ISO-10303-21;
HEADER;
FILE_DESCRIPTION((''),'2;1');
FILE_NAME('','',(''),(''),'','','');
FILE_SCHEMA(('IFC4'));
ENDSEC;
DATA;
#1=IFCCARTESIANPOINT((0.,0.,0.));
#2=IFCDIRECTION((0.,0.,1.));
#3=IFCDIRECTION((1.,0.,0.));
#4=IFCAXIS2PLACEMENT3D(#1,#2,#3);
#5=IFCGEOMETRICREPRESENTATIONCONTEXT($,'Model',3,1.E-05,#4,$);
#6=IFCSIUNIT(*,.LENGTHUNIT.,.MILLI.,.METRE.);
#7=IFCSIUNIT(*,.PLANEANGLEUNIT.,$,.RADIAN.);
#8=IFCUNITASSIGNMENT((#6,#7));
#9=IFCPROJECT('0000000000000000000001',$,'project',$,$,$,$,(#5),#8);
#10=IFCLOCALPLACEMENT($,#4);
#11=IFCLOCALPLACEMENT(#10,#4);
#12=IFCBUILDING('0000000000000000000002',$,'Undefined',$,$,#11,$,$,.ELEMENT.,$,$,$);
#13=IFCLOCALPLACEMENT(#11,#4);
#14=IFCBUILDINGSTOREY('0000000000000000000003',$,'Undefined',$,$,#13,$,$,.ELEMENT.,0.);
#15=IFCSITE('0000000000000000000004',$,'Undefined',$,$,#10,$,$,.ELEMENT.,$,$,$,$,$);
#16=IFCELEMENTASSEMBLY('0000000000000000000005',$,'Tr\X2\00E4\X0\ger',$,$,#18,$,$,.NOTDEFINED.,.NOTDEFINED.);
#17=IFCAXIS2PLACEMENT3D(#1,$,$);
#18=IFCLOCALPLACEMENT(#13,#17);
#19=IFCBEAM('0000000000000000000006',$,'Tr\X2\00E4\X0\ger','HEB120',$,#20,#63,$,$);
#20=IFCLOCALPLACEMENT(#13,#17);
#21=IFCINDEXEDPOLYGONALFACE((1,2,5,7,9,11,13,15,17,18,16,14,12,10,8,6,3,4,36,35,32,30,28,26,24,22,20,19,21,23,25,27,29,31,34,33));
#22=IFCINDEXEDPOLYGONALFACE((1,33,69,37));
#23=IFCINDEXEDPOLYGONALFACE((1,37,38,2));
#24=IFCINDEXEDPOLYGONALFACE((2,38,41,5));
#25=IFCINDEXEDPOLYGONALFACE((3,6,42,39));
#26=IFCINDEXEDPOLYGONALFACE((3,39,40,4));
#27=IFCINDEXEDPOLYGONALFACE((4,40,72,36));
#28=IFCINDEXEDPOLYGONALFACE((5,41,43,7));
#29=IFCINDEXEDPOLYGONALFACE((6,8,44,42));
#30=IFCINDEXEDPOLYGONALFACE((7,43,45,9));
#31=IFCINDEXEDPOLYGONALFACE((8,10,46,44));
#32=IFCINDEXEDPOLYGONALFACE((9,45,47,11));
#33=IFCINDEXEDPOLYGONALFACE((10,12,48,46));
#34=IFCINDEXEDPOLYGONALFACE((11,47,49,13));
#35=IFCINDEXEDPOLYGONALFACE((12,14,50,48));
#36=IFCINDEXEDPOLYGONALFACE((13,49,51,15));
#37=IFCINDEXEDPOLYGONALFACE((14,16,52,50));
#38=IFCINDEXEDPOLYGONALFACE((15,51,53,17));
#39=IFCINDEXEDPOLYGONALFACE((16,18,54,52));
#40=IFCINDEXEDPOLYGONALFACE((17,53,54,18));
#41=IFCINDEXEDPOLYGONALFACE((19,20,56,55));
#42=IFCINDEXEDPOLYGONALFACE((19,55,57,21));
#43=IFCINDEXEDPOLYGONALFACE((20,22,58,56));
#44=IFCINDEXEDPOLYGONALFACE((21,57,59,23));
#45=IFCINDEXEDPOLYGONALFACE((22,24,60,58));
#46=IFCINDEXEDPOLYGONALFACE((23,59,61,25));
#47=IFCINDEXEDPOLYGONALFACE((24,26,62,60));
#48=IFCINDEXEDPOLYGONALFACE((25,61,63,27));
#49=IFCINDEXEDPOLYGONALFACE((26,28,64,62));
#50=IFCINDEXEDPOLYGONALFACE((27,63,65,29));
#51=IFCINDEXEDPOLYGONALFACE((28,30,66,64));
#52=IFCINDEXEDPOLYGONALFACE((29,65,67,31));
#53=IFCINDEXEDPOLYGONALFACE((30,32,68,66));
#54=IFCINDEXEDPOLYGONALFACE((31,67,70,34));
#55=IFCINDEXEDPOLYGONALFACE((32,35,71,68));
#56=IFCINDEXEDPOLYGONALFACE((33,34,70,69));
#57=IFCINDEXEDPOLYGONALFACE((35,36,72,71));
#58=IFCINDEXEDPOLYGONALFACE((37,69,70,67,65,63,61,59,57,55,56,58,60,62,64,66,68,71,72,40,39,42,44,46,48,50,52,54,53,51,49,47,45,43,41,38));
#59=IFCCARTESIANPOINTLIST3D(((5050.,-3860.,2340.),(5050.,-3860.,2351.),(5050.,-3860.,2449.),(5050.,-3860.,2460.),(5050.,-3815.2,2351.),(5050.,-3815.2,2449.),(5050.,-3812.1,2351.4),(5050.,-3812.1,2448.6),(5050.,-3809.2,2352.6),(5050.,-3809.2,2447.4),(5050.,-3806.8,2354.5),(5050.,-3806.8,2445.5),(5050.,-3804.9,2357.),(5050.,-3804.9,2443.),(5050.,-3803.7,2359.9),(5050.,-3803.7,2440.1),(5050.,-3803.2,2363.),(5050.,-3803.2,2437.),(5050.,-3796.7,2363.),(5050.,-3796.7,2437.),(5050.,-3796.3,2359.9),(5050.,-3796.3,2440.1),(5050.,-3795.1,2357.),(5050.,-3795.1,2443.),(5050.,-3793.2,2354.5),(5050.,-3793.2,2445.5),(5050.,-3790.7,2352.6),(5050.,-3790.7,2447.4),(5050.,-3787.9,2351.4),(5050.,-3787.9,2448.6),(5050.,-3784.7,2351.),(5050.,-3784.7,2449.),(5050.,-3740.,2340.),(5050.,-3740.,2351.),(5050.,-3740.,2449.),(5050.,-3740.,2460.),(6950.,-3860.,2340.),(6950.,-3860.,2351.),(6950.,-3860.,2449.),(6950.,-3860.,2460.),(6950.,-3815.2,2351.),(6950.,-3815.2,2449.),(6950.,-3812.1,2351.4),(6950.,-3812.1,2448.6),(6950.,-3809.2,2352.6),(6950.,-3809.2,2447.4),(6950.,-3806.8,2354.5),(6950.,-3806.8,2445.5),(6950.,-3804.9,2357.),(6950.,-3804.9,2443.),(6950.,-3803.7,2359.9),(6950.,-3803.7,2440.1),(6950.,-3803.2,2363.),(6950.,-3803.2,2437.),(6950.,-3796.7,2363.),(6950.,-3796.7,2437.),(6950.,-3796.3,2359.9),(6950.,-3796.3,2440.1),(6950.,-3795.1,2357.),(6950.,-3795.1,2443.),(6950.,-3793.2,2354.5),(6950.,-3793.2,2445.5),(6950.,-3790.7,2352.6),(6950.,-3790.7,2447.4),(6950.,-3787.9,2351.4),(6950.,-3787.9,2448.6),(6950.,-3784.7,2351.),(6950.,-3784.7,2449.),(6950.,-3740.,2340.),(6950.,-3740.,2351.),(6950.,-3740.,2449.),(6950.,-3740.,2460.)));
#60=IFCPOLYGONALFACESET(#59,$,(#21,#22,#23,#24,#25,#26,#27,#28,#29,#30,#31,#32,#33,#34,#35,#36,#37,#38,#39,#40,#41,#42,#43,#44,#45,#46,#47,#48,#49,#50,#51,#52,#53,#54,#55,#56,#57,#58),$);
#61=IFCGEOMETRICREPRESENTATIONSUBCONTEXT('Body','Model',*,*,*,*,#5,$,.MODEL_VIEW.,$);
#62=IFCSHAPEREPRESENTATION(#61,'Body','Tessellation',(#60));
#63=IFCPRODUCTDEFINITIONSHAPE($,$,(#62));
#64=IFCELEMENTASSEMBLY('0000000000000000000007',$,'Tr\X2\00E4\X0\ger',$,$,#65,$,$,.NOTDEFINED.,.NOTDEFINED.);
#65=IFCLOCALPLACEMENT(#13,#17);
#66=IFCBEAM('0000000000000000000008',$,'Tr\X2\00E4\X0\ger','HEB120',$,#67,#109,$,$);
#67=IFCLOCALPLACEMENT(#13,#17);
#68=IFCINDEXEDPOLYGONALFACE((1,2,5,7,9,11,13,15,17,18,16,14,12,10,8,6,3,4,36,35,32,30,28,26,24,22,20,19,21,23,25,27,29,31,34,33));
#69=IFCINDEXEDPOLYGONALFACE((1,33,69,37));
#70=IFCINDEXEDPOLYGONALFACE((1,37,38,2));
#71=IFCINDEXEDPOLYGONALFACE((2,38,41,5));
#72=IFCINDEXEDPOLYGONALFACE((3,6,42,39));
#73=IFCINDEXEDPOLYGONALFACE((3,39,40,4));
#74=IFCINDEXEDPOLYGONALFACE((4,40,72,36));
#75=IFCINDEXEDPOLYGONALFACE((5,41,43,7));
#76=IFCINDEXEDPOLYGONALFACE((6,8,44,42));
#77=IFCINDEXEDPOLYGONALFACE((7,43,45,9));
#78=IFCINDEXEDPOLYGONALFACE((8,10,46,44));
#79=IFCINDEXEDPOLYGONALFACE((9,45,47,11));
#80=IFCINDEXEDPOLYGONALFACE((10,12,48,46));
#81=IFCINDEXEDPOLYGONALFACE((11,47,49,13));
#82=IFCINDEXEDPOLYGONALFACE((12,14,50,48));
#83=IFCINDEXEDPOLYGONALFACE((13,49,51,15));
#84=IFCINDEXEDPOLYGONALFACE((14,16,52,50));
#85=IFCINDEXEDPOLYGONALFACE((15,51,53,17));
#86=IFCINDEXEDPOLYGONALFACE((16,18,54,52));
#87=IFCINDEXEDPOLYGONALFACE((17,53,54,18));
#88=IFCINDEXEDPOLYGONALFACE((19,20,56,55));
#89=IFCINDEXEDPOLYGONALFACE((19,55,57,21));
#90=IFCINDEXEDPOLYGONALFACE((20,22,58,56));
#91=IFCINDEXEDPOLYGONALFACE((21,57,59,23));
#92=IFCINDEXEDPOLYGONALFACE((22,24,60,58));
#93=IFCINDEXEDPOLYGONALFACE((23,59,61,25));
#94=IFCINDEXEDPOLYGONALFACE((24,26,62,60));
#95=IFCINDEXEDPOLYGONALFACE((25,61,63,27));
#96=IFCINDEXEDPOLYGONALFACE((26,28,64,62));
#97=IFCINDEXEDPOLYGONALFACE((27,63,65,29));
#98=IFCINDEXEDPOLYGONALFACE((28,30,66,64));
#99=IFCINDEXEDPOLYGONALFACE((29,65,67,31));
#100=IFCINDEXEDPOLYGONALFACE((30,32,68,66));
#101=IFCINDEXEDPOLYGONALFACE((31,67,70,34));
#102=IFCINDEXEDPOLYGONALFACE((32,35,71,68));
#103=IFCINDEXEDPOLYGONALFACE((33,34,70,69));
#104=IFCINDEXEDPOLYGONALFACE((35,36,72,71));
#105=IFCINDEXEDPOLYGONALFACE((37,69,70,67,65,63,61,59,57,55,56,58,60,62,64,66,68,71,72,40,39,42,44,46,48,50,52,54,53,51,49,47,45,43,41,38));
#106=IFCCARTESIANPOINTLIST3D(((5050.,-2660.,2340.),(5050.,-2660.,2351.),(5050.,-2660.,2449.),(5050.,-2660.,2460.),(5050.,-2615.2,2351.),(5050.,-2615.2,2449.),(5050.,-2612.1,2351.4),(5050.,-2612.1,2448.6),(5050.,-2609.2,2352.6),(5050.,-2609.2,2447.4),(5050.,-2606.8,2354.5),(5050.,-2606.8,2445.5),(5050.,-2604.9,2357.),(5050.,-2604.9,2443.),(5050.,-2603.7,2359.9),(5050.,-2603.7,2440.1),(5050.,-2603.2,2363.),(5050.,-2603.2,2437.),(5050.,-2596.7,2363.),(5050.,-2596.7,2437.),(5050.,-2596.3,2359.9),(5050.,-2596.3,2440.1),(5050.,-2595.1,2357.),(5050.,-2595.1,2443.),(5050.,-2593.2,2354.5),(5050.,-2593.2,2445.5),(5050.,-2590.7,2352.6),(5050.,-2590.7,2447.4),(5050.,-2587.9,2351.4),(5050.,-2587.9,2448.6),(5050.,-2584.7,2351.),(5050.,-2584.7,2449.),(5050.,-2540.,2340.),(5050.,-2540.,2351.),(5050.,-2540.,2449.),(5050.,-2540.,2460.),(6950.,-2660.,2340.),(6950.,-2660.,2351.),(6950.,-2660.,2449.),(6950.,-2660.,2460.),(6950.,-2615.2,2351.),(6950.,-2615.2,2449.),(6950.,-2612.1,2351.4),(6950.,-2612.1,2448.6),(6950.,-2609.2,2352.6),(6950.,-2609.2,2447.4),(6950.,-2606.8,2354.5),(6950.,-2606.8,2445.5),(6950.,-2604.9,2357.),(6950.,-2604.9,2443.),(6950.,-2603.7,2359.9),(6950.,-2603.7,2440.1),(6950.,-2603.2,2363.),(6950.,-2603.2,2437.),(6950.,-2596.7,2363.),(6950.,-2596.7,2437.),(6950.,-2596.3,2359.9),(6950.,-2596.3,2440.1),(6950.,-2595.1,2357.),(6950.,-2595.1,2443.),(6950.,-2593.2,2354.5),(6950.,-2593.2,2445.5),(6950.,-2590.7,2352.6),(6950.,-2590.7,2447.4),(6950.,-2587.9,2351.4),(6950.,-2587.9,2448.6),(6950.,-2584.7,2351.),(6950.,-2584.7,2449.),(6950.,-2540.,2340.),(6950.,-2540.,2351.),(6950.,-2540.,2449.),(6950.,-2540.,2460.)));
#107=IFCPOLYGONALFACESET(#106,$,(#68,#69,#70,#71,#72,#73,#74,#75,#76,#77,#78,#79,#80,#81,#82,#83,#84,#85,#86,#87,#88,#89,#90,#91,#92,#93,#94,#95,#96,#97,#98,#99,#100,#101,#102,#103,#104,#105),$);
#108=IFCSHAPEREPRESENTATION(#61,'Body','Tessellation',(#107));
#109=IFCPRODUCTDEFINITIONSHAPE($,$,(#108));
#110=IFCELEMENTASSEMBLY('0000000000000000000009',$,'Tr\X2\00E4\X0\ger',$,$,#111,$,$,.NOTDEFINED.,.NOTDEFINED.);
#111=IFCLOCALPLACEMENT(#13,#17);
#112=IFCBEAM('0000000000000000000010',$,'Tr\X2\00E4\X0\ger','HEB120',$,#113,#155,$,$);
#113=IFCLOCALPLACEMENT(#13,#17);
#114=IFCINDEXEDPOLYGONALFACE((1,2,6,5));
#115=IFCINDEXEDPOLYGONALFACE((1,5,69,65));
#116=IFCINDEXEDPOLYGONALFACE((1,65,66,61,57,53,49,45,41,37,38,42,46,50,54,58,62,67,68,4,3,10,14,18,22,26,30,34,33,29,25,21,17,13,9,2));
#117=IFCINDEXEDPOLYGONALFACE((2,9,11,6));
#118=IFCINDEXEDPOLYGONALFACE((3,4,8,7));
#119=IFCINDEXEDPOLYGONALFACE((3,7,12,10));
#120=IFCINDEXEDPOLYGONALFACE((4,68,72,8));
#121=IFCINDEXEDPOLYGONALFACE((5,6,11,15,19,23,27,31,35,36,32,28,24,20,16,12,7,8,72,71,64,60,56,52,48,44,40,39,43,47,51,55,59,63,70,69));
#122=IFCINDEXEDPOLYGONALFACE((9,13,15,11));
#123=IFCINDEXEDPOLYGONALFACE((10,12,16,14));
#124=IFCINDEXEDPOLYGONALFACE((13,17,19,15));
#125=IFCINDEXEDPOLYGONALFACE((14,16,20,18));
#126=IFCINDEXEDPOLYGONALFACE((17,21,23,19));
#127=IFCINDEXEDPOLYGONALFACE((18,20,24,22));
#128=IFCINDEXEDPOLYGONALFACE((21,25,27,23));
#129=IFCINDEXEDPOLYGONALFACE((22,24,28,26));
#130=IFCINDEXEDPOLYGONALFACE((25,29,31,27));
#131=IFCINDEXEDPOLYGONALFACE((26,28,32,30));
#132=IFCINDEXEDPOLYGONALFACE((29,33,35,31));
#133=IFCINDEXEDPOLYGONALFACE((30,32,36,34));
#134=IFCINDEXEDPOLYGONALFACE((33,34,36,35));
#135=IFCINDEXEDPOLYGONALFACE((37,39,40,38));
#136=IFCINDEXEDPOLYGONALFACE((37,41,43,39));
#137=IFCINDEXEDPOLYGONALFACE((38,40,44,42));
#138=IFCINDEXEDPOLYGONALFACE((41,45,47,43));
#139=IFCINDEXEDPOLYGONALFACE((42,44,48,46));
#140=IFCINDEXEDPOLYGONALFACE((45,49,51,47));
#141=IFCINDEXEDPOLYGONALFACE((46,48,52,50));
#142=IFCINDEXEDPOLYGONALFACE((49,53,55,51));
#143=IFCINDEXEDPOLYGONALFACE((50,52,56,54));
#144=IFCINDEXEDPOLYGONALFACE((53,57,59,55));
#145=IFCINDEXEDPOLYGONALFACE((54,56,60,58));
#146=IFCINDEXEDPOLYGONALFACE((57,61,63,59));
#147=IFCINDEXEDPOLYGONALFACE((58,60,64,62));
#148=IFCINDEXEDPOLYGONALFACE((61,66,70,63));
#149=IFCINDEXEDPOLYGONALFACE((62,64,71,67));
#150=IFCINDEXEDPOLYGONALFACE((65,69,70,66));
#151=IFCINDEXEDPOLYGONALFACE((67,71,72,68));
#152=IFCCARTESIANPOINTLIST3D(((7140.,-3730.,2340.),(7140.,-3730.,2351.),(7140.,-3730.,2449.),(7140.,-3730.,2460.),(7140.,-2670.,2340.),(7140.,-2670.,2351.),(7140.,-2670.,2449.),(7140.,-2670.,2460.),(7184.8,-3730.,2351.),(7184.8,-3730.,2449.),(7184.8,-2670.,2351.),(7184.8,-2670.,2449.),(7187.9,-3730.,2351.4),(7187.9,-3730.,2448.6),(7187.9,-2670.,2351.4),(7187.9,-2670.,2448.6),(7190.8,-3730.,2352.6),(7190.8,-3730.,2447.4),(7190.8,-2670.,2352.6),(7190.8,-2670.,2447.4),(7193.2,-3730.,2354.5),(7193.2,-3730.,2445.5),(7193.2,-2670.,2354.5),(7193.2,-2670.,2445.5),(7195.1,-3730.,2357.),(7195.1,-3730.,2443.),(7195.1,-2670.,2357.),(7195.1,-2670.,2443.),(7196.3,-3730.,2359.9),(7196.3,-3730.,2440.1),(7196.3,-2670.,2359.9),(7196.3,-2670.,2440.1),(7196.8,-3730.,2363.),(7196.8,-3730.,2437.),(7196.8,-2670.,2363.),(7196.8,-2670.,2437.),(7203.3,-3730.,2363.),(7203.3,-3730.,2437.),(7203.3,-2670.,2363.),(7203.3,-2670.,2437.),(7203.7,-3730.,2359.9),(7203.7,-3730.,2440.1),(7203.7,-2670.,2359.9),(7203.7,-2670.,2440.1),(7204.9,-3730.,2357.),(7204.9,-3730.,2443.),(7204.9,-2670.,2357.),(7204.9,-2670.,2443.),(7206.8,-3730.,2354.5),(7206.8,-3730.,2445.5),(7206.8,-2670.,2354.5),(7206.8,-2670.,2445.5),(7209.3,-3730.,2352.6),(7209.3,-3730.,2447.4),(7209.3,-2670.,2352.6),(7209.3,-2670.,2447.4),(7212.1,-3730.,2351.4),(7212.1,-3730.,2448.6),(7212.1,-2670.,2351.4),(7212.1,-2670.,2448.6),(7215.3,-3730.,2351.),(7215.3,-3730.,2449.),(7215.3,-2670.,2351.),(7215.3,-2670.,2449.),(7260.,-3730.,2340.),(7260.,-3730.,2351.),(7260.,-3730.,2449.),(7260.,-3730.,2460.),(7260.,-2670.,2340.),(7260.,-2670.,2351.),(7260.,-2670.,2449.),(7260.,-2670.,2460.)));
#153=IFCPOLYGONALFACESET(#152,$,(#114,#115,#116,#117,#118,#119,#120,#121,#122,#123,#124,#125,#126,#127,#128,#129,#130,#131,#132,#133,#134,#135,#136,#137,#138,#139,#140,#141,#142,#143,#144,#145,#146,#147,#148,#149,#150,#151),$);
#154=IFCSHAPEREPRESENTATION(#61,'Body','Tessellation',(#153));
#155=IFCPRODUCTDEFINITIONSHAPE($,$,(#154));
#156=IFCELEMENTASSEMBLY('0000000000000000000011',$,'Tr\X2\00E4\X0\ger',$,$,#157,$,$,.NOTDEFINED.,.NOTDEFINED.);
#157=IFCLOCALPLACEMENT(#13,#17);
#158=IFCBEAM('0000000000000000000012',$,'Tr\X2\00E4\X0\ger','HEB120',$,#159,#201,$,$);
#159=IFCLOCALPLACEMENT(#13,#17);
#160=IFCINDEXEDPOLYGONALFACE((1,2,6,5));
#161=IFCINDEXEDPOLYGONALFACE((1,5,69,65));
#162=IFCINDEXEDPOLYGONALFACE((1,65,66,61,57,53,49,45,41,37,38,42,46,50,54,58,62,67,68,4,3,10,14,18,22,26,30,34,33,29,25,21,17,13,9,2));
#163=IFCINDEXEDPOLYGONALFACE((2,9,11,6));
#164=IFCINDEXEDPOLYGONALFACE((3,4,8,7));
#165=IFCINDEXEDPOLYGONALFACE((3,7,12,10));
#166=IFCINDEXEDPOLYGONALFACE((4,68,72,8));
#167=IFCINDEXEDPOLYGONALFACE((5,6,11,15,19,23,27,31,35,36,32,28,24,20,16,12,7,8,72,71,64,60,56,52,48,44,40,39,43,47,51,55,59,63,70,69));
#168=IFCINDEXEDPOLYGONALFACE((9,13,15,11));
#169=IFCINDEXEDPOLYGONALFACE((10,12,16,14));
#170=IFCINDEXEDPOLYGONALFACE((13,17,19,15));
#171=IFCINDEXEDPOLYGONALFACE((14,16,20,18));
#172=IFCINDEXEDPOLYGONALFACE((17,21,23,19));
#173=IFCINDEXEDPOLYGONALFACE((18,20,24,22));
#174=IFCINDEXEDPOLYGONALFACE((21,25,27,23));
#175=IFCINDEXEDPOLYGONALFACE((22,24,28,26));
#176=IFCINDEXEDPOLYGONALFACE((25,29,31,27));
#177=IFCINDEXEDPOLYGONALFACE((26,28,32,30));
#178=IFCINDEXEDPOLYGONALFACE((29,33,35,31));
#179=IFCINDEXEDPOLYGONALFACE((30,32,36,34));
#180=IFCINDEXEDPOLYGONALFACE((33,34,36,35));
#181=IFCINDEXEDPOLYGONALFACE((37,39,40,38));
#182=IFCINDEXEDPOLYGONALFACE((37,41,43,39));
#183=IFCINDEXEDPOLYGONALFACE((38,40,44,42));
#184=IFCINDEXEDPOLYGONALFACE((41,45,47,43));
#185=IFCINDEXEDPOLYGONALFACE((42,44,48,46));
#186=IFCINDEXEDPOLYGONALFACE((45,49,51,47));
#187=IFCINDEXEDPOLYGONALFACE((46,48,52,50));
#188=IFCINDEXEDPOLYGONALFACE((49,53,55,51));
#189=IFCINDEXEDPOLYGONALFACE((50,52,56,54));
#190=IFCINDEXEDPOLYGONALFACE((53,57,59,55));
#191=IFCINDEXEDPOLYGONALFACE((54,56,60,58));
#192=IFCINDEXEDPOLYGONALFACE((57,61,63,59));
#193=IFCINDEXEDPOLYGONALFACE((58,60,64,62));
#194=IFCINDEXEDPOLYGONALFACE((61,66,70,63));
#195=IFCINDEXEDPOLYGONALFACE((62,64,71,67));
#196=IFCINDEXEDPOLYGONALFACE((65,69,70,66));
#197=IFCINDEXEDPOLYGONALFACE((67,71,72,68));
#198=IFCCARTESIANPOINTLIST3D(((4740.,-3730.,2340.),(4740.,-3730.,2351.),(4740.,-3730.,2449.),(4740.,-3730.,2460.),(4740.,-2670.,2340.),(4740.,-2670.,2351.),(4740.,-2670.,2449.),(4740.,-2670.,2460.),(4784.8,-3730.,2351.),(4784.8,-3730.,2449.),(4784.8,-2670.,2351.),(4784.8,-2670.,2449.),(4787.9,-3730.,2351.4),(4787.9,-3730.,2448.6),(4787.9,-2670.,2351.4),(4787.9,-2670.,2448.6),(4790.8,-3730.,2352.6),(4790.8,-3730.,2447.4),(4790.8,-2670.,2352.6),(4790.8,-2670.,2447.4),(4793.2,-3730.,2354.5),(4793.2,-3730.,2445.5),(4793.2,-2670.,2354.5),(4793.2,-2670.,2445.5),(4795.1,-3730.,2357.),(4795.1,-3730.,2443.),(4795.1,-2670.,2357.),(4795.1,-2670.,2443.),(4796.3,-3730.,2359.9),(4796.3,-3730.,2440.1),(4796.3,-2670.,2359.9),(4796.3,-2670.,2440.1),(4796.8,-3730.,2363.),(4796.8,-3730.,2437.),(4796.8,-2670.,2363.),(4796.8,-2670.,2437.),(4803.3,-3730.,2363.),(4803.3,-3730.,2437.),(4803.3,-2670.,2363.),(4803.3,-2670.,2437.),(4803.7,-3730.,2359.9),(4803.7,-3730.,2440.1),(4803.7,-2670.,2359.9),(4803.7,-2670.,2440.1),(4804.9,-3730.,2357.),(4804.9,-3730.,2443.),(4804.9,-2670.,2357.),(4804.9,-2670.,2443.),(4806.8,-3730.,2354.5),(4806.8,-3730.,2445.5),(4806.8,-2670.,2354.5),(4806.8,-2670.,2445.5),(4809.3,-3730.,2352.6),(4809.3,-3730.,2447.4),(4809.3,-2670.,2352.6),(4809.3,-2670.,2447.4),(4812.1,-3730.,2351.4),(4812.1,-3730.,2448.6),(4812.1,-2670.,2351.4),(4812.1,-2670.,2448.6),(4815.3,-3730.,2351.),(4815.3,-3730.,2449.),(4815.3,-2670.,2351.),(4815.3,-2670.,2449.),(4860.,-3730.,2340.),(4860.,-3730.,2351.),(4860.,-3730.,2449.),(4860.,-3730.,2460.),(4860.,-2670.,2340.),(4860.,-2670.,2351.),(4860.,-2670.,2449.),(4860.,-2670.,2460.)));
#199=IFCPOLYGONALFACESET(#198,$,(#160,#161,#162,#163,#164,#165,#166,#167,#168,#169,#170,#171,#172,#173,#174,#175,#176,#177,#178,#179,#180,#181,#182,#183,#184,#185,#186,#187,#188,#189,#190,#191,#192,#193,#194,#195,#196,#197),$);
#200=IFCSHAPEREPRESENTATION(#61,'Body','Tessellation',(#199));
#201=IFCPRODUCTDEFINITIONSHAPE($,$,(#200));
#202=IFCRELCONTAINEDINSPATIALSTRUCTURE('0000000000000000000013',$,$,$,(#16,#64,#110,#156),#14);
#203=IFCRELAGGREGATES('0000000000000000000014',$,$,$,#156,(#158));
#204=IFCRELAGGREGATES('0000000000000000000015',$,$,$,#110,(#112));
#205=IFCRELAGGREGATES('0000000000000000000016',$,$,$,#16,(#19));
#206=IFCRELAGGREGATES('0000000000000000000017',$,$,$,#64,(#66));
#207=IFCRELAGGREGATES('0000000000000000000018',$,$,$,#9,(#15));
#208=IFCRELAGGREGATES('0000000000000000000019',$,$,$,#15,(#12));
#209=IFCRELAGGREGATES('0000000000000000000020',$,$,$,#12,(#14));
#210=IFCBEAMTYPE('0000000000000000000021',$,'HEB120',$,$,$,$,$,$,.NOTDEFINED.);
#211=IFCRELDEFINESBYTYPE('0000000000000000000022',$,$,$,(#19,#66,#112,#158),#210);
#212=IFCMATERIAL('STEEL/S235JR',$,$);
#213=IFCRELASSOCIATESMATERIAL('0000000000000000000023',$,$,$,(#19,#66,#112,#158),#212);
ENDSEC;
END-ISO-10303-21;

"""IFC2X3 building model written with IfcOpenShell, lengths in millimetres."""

from ifc_helpers import new_model, si_unit, frame, origin_with_axes, origin_2d_with_axis, place, context, subcontext, project, spatial, i_section, extrude, clip, halfspace, material, type_object, element, aggregate, save


model = new_model("IFC2X3")

# Units and contexts
model_context = context("Model", 3, precision=1e-05, world=origin_with_axes())
body_context = subcontext(model_context, "Body", "Model", "MODEL_VIEW")
ifc_project = project(units=[si_unit("LENGTHUNIT", "METRE", prefix="MILLI"), si_unit("PLANEANGLEUNIT", "RADIAN")], contexts=[model_context])

# Site, building, storey
site_placement = place(None, origin_with_axes())
site = spatial("IfcSite", under=ifc_project, at=site_placement, Name="Undefined", CompositionType="ELEMENT")
building_placement = place(site_placement, origin_with_axes())
building = spatial("IfcBuilding", under=site, at=building_placement, Name="Undefined", CompositionType="ELEMENT")
storey_placement = place(building_placement, origin_with_axes())
storey = spatial("IfcBuildingStorey", under=building, at=storey_placement, Name="Undefined", CompositionType="ELEMENT", Elevation=0.0)

# Element assemblies, beams
ifc_material_1 = material(Name="STEEL/S235JR")
beam_type = type_object("IfcBeamType", Name="HEB120", PredefinedType="NOTDEFINED")
assembly_1_placement = place(storey_placement, origin_with_axes())
assembly_1 = element("IfcElementAssembly", 1, at=assembly_1_placement, inside=storey, Name="Träger", AssemblyPlace="NOTDEFINED", PredefinedType="NOTDEFINED")
beam_1_placement = place(assembly_1_placement, frame((6950.0, -3800.0, 2400.0), z_axis=(0.0, 0.0, 1.0), x_axis=(-1.0, 0.0, 0.0)))
beam_1 = element("IfcBeam", 2, at=beam_1_placement, type_object=beam_type, material=ifc_material_1, Name="Träger", Description="HEB120", context=body_context, shape_type="Clipping", body=[
    clip(clip(extrude(i_section(OverallWidth=120.0, OverallDepth=120.0, WebThickness=6.5, FlangeThickness=11.0, FilletRadius=12.0, at=origin_2d_with_axis()), frame((1910.0, 0.0, 0.0), z_axis=(-1.0, 0.0, 0.0), x_axis=(0.0, -1.0, 0.0)), (0.0, 0.0, 1.0), 1910.0), halfspace(frame((1900.0, 0.0, -60.0), z_axis=(-1.0, 0.0, 0.0), x_axis=(0.0, 1.0, 0.0)), True)), halfspace(frame((0.0, 0.0, -60.0), z_axis=(1.0, 0.0, 0.0), x_axis=(0.0, -1.0, 0.0)), True)),
])
assembly_2_placement = place(storey_placement, origin_with_axes())
assembly_2 = element("IfcElementAssembly", 3, at=assembly_2_placement, inside=storey, Name="Träger", AssemblyPlace="NOTDEFINED", PredefinedType="NOTDEFINED")
beam_2_placement = place(assembly_2_placement, frame((6950.0, -2600.0, 2400.0), z_axis=(0.0, 0.0, 1.0), x_axis=(-1.0, 0.0, 0.0)))
beam_2 = element("IfcBeam", 4, at=beam_2_placement, type_object=beam_type, material=ifc_material_1, Name="Träger", Description="HEB120", context=body_context, shape_type="Clipping", body=[
    clip(clip(extrude(i_section(OverallWidth=120.0, OverallDepth=120.0, WebThickness=6.5, FlangeThickness=11.0, FilletRadius=12.0, at=origin_2d_with_axis()), frame((1910.0, 0.0, 0.0), z_axis=(-1.0, 0.0, 0.0), x_axis=(0.0, -1.0, 0.0)), (0.0, 0.0, 1.0), 1910.0), halfspace(frame((1900.0, 0.0, -60.0), z_axis=(-1.0, 0.0, 0.0), x_axis=(0.0, 1.0, 0.0)), True)), halfspace(frame((0.0, 0.0, -60.0), z_axis=(1.0, 0.0, 0.0), x_axis=(0.0, -1.0, 0.0)), True)),
])
assembly_3_placement = place(storey_placement, origin_with_axes())
assembly_3 = element("IfcElementAssembly", 5, at=assembly_3_placement, inside=storey, Name="Träger", AssemblyPlace="NOTDEFINED", PredefinedType="NOTDEFINED")
beam_3_placement = place(assembly_3_placement, frame((7200.0, -2670.0, 2400.0), z_axis=(0.0, 0.0, 1.0), x_axis=(0.0, -1.0, 0.0)))
beam_3 = element("IfcBeam", 6, at=beam_3_placement, type_object=beam_type, material=ifc_material_1, Name="Träger", Description="HEB120", context=body_context, shape_type="Clipping", body=[
    clip(clip(extrude(i_section(OverallWidth=120.0, OverallDepth=120.0, WebThickness=6.5, FlangeThickness=11.0, FilletRadius=12.0, at=origin_2d_with_axis()), frame((1060.0, 0.0, 0.0), z_axis=(-1.0, 0.0, 0.0), x_axis=(0.0, -1.0, 0.0)), (0.0, 0.0, 1.0), 1060.0), halfspace(frame((1060.0, 0.0, -60.0), z_axis=(-1.0, 0.0, 0.0), x_axis=(0.0, 1.0, 0.0)), True)), halfspace(frame((0.0, 0.0, -60.0), z_axis=(1.0, 0.0, 0.0), x_axis=(0.0, -1.0, 0.0)), True)),
])
assembly_4_placement = place(storey_placement, origin_with_axes())
assembly_4 = element("IfcElementAssembly", 7, at=assembly_4_placement, inside=storey, Name="Träger", AssemblyPlace="NOTDEFINED", PredefinedType="NOTDEFINED")
beam_4_placement = place(assembly_4_placement, frame((4800.0, -2670.0, 2400.0), z_axis=(0.0, 0.0, 1.0), x_axis=(0.0, -1.0, 0.0)))
beam_4 = element("IfcBeam", 8, at=beam_4_placement, type_object=beam_type, material=ifc_material_1, Name="Träger", Description="HEB120", context=body_context, shape_type="Clipping", body=[
    clip(clip(extrude(i_section(OverallWidth=120.0, OverallDepth=120.0, WebThickness=6.5, FlangeThickness=11.0, FilletRadius=12.0, at=origin_2d_with_axis()), frame((1060.0, 0.0, 0.0), z_axis=(-1.0, 0.0, 0.0), x_axis=(0.0, -1.0, 0.0)), (0.0, 0.0, 1.0), 1060.0), halfspace(frame((1060.0, 0.0, -60.0), z_axis=(-1.0, 0.0, 0.0), x_axis=(0.0, 1.0, 0.0)), True)), halfspace(frame((0.0, 0.0, -60.0), z_axis=(1.0, 0.0, 0.0), x_axis=(0.0, -1.0, 0.0)), True)),
])
aggregate(assembly_4, [beam_4])

aggregate(assembly_3, [beam_3])

aggregate(assembly_1, [beam_1])
aggregate(assembly_2, [beam_2])

save(model, "model.ifc")
